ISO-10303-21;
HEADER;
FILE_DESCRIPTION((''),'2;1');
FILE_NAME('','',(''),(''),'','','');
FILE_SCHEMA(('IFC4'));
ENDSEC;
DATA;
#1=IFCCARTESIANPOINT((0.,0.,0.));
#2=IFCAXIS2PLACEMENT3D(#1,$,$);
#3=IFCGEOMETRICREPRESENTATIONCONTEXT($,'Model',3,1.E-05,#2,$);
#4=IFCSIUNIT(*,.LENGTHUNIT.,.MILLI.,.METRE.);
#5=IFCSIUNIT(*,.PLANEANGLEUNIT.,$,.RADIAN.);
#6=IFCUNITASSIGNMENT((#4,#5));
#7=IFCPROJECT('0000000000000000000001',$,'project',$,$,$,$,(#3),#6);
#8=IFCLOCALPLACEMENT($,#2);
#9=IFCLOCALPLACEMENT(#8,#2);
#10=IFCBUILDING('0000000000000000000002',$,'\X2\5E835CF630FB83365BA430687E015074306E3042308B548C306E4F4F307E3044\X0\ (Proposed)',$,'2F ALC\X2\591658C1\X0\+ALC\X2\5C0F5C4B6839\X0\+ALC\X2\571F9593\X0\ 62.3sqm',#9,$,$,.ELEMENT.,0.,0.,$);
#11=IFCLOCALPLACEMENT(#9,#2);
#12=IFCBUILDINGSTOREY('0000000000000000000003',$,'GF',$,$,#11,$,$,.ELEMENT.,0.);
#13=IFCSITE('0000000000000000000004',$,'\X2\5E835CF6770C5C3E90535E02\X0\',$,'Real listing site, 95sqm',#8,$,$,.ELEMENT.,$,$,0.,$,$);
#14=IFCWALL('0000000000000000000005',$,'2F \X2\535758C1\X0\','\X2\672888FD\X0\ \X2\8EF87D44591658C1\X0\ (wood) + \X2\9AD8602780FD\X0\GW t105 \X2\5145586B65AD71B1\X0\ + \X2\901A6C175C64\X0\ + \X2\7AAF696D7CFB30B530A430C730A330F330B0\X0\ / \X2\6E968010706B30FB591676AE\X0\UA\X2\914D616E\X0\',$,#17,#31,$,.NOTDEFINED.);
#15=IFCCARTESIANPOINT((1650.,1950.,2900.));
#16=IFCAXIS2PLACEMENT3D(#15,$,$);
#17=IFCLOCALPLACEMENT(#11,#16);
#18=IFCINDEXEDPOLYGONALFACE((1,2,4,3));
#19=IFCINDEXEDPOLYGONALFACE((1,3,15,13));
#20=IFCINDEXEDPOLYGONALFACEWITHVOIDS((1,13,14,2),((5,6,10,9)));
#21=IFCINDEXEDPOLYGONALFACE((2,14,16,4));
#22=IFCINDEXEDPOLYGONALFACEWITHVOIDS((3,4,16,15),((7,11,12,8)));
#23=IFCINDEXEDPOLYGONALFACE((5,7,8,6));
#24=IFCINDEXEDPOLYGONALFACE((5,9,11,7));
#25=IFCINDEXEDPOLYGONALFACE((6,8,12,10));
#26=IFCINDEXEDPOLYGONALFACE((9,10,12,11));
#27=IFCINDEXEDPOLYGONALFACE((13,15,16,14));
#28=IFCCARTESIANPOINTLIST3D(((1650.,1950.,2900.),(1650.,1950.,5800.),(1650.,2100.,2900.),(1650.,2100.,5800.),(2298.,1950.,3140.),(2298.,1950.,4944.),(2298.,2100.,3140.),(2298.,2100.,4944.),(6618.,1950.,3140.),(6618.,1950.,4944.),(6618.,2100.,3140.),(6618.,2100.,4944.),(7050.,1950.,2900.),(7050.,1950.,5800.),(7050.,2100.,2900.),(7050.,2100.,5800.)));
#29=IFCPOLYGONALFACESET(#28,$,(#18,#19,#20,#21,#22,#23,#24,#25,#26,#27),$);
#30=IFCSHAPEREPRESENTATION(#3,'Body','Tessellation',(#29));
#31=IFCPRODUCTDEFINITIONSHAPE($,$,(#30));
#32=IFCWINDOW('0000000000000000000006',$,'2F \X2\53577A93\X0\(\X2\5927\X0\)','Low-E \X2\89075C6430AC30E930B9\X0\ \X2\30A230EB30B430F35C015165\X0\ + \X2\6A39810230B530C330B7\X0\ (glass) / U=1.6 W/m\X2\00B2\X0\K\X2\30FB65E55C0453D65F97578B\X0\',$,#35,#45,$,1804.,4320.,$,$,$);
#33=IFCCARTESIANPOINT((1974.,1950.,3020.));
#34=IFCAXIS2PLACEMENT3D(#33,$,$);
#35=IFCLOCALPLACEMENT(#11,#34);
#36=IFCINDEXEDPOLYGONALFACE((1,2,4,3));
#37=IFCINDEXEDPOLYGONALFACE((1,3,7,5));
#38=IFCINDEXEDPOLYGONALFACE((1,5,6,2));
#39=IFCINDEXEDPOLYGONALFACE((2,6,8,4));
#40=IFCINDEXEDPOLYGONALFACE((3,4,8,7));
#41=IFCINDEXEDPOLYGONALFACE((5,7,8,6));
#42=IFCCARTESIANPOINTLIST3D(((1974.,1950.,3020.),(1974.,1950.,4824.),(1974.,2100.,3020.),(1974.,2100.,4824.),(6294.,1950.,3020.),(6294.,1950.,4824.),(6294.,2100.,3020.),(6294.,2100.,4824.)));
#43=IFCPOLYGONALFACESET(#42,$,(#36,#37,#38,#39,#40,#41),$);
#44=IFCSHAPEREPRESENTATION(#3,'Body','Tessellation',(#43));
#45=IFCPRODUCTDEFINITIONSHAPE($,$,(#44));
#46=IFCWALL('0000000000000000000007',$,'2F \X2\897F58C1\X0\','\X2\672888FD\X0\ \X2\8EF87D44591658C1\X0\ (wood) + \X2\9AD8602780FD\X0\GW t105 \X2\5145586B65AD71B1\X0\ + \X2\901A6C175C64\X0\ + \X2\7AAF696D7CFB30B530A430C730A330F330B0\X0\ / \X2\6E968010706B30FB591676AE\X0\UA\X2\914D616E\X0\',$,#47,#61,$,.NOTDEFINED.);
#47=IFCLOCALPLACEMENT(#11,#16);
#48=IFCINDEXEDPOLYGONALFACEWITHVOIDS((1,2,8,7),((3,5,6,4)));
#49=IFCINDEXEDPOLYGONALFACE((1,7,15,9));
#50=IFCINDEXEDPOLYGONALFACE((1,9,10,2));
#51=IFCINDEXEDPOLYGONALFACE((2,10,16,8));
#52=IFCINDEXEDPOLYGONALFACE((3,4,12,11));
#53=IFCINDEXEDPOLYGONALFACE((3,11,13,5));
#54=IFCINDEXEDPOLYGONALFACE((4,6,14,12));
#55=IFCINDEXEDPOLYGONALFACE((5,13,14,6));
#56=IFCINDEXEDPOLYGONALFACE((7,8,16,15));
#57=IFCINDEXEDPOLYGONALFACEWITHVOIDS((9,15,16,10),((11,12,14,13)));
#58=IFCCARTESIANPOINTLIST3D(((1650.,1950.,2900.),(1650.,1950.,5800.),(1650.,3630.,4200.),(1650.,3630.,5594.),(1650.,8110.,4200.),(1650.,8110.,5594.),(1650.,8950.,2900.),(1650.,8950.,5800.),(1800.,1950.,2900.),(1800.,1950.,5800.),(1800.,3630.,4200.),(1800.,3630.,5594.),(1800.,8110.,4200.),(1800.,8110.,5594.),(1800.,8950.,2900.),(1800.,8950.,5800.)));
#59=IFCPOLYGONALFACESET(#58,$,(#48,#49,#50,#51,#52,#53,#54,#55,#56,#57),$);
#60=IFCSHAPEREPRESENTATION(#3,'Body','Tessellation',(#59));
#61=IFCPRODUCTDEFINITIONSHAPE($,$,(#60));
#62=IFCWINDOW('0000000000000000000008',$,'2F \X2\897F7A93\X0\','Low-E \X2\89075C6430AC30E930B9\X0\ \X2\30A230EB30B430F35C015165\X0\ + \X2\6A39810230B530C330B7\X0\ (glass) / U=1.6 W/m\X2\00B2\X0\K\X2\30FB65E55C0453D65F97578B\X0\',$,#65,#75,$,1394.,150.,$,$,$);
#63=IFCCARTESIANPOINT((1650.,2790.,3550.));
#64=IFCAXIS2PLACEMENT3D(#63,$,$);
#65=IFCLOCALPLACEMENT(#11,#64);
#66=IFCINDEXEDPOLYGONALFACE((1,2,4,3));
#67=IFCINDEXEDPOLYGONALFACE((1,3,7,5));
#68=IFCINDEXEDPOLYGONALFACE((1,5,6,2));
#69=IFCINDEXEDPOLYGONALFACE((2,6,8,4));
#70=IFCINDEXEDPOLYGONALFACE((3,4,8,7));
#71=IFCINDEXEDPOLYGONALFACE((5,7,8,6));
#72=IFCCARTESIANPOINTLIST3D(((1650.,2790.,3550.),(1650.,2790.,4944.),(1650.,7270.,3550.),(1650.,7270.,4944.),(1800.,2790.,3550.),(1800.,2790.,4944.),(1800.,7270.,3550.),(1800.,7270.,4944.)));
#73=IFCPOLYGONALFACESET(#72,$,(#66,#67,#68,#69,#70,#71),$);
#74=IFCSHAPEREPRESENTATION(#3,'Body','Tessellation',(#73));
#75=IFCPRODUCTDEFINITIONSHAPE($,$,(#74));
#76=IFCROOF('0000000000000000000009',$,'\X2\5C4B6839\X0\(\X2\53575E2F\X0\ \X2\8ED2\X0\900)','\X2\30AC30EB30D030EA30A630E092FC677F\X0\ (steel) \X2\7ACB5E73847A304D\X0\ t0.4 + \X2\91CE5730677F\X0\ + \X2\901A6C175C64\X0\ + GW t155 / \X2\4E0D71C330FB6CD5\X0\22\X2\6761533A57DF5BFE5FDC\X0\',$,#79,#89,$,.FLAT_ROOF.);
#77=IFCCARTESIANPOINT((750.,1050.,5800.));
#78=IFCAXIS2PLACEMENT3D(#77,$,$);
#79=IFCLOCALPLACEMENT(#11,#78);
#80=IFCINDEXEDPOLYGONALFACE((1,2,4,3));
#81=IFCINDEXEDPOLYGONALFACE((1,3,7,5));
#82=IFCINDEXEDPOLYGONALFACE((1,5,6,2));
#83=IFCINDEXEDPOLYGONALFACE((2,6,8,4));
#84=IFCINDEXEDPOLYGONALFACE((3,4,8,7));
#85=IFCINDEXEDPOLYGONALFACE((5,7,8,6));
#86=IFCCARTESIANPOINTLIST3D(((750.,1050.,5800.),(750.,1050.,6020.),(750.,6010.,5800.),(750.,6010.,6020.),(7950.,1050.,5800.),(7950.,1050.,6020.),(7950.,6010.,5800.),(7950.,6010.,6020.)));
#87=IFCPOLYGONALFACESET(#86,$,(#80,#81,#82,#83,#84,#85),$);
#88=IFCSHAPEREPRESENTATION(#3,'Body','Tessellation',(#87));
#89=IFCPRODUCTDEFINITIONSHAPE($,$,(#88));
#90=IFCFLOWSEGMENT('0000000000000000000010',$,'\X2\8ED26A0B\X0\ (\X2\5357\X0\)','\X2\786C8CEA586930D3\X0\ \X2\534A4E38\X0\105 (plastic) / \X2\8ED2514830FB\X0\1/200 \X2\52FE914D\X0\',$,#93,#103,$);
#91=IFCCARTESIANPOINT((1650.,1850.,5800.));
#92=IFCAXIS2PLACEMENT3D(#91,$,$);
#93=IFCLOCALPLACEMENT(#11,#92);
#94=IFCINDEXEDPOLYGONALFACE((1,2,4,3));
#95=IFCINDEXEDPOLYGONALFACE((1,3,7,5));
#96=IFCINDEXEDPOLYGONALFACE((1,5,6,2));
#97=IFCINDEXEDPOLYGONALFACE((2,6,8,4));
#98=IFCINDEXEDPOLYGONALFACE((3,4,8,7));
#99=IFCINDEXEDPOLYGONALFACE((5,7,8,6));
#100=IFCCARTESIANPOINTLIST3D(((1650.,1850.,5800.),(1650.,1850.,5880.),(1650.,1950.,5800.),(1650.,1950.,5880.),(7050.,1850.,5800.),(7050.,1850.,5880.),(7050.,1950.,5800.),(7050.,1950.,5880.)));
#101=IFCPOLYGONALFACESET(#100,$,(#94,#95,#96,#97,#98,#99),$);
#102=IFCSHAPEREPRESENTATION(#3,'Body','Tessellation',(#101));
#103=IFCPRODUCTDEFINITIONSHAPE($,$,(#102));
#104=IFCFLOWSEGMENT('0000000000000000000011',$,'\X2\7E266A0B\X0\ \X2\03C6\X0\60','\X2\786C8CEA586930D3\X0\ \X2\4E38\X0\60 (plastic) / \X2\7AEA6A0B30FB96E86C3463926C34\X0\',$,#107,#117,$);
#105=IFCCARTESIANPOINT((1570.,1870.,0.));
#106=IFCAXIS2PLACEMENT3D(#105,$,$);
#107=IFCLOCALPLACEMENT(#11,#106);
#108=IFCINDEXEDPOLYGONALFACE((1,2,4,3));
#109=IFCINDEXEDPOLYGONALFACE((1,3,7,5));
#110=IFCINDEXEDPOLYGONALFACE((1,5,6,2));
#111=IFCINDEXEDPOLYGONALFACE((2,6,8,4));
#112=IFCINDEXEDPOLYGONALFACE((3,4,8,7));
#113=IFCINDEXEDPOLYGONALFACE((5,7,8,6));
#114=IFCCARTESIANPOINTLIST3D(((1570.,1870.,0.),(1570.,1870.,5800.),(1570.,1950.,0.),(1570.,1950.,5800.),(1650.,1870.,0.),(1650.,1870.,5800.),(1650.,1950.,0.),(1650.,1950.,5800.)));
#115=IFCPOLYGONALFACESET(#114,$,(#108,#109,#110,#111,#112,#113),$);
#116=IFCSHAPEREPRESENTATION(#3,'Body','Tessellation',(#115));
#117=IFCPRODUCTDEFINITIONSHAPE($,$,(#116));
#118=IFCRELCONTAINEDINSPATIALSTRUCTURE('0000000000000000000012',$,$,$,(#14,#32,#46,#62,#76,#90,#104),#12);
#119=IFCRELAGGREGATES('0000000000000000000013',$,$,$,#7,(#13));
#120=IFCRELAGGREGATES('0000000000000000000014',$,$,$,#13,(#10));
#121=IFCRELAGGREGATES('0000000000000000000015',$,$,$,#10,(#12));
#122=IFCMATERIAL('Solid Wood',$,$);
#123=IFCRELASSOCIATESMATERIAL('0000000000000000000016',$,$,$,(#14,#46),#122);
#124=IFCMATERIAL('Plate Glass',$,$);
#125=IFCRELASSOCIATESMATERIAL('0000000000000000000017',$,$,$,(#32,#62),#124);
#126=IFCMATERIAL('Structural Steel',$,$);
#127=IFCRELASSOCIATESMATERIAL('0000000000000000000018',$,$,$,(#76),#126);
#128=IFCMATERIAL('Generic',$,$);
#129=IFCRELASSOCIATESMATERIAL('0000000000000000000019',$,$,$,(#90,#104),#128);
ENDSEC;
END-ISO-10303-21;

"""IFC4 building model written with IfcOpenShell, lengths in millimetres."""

from ifc_helpers import new_model, si_unit, frame, frame_2d, origin, place, context, project, spatial, rectangle, extrude, material, element, fill, save


model = new_model("IFC4")

# Units and contexts
model_context = context("Model", 3, precision=1e-05, world=origin())
ifc_project = project(units=[si_unit("LENGTHUNIT", "METRE", prefix="MILLI"), si_unit("PLANEANGLEUNIT", "RADIAN")], contexts=[model_context])

# Site, building, storey
site_placement = place(None, origin())
site = spatial("IfcSite", under=ifc_project, at=site_placement, Name="広島県尾道市", ObjectType="Real listing site, 95sqm", CompositionType="ELEMENT", RefElevation=0.0)
building_placement = place(site_placement, origin())
building = spatial("IfcBuilding", under=site, at=building_placement, Name="広島・茶室と縁側のある和の住まい (Proposed)", ObjectType="2F ALC外壁+ALC小屋根+ALC土間 62.3sqm", CompositionType="ELEMENT", ElevationOfRefHeight=0.0, ElevationOfTerrain=0.0)
storey_placement = place(building_placement, origin())
storey = spatial("IfcBuildingStorey", under=building, at=storey_placement, Name="GF", CompositionType="ELEMENT", Elevation=0.0)

# Shared definitions
ifc_material_1 = material(Name="Solid Wood")

# Shared definitions
ifc_material_2 = material(Name="Plate Glass")

# Walls, openings, windows
wall_1_placement = place(storey_placement, frame((1650.0, 1950.0, 2900.0)))
wall_1 = element("IfcWall", 1, at=wall_1_placement, inside=storey, material=ifc_material_1, Name="2F 南壁", Description="木製 軸組外壁 (wood) + 高性能GW t105 充填断熱 + 通気層 + 窯業系サイディング / 準耐火・外皮UA配慮", PredefinedType="NOTDEFINED", context=model_context, shape_type="SweptSolid", body=[
    extrude(rectangle(XDim=5400.0, YDim=150.0, at=frame_2d((2700.0, 75.0))), frame((1650.0, 1950.0, 2900.0)), (0.0, 0.0, 1.0), 2900.0),
])
opening_1_placement = place(storey_placement, frame((1974.0, 1950.0, 3020.0)))
opening_1 = element("IfcOpeningElement", 2, at=opening_1_placement, cuts=wall_1, PredefinedType="NOTDEFINED", context=model_context, shape_type="SweptSolid", body=[
    extrude(rectangle(XDim=4320.0, YDim=150.0, at=frame_2d((2160.0, 75.0))), frame((1974.0, 1950.0, 3020.0)), (0.0, 0.0, 1.0), 1804.0),
])
window_1_placement = place(storey_placement, frame((1974.0, 1950.0, 3020.0)))
window_1 = element("IfcWindow", 3, at=window_1_placement, inside=storey, material=ifc_material_2, Name="2F 南窓(大)", Description="Low-E 複層ガラス アルゴン封入 + 樹脂サッシ (glass) / U=1.6 W/m²K・日射取得型", OverallHeight=1804.0, OverallWidth=4320.0, context=model_context, shape_type="SweptSolid", body=[
    extrude(rectangle(XDim=4320.0, YDim=150.0, at=frame_2d((2160.0, 75.0))), frame((1974.0, 1950.0, 3020.0)), (0.0, 0.0, 1.0), 1804.0),
])
fill(opening_1, window_1)
wall_2_placement = place(storey_placement, frame((1650.0, 1950.0, 2900.0)))
wall_2 = element("IfcWall", 4, at=wall_2_placement, inside=storey, material=ifc_material_1, Name="2F 西壁", Description="木製 軸組外壁 (wood) + 高性能GW t105 充填断熱 + 通気層 + 窯業系サイディング / 準耐火・外皮UA配慮", PredefinedType="NOTDEFINED", context=model_context, shape_type="SweptSolid", body=[
    extrude(rectangle(XDim=150.0, YDim=7000.0, at=frame_2d((75.0, 3500.0))), frame((1650.0, 1950.0, 2900.0)), (0.0, 0.0, 1.0), 2900.0),
])
opening_2_placement = place(storey_placement, frame((1650.0, 2790.0, 3550.0)))
opening_2 = element("IfcOpeningElement", 5, at=opening_2_placement, cuts=wall_2, PredefinedType="NOTDEFINED", context=model_context, shape_type="SweptSolid", body=[
    extrude(rectangle(XDim=150.0, YDim=4480.0, at=frame_2d((75.0, 2240.0))), frame((1650.0, 2790.0, 3550.0)), (0.0, 0.0, 1.0), 1394.0),
])
window_2_placement = place(storey_placement, frame((1650.0, 2790.0, 3550.0)))
window_2 = element("IfcWindow", 6, at=window_2_placement, inside=storey, material=ifc_material_2, Name="2F 西窓", Description="Low-E 複層ガラス アルゴン封入 + 樹脂サッシ (glass) / U=1.6 W/m²K・日射取得型", OverallHeight=1394.0, OverallWidth=150.0, context=model_context, shape_type="SweptSolid", body=[
    extrude(rectangle(XDim=150.0, YDim=4480.0, at=frame_2d((75.0, 2240.0))), frame((1650.0, 2790.0, 3550.0)), (0.0, 0.0, 1.0), 1394.0),
])
fill(opening_2, window_2)

# Roof
ifc_material_3 = material(Name="Structural Steel")
for number, where, name in (
    (7, (750.0, 1050.0, 5800.0), "屋根(南帯 軒900)"),
):
    element("IfcRoof", number, at=place(storey_placement, frame(where)), inside=storey, material=ifc_material_3, Name=name, Description="ガルバリウム鋼板 (steel) 立平葺き t0.4 + 野地板 + 通気層 + GW t155 / 不燃・法22条区域対応", PredefinedType="FLAT_ROOF", context=model_context, shape_type="SweptSolid", body=[
        extrude(rectangle(XDim=7200.0, YDim=4960.0, at=frame_2d((3600.0, 2480.0))), frame((750.0, 1050.0, 5800.0)), (0.0, 0.0, 1.0), 220.0),
    ])

# Flow segments
ifc_material_4 = material(Name="Generic")
flow_segment_1_placement = place(storey_placement, frame((1650.0, 1850.0, 5800.0)))
element("IfcFlowSegment", 8, at=flow_segment_1_placement, inside=storey, material=ifc_material_4, Name="軒樋 (南)", Description="硬質塩ビ 半丸105 (plastic) / 軒先・1/200 勾配", context=model_context, shape_type="SweptSolid", body=[
    extrude(rectangle(XDim=5400.0, YDim=100.0, at=frame_2d((2700.0, 50.0))), frame((1650.0, 1850.0, 5800.0)), (0.0, 0.0, 1.0), 80.0),
])
flow_segment_2_placement = place(storey_placement, frame((1570.0, 1870.0, 0.0)))
element("IfcFlowSegment", 9, at=flow_segment_2_placement, inside=storey, material=ifc_material_4, Name="縦樋 φ60", Description="硬質塩ビ 丸60 (plastic) / 竪樋・雨水排水", context=model_context, shape_type="SweptSolid", body=[
    extrude(rectangle(XDim=80.0, YDim=80.0, at=frame_2d((40.0, 40.0))), frame((1570.0, 1870.0, 0.0)), (0.0, 0.0, 1.0), 5800.0),
])

save(model, "model.ifc")
